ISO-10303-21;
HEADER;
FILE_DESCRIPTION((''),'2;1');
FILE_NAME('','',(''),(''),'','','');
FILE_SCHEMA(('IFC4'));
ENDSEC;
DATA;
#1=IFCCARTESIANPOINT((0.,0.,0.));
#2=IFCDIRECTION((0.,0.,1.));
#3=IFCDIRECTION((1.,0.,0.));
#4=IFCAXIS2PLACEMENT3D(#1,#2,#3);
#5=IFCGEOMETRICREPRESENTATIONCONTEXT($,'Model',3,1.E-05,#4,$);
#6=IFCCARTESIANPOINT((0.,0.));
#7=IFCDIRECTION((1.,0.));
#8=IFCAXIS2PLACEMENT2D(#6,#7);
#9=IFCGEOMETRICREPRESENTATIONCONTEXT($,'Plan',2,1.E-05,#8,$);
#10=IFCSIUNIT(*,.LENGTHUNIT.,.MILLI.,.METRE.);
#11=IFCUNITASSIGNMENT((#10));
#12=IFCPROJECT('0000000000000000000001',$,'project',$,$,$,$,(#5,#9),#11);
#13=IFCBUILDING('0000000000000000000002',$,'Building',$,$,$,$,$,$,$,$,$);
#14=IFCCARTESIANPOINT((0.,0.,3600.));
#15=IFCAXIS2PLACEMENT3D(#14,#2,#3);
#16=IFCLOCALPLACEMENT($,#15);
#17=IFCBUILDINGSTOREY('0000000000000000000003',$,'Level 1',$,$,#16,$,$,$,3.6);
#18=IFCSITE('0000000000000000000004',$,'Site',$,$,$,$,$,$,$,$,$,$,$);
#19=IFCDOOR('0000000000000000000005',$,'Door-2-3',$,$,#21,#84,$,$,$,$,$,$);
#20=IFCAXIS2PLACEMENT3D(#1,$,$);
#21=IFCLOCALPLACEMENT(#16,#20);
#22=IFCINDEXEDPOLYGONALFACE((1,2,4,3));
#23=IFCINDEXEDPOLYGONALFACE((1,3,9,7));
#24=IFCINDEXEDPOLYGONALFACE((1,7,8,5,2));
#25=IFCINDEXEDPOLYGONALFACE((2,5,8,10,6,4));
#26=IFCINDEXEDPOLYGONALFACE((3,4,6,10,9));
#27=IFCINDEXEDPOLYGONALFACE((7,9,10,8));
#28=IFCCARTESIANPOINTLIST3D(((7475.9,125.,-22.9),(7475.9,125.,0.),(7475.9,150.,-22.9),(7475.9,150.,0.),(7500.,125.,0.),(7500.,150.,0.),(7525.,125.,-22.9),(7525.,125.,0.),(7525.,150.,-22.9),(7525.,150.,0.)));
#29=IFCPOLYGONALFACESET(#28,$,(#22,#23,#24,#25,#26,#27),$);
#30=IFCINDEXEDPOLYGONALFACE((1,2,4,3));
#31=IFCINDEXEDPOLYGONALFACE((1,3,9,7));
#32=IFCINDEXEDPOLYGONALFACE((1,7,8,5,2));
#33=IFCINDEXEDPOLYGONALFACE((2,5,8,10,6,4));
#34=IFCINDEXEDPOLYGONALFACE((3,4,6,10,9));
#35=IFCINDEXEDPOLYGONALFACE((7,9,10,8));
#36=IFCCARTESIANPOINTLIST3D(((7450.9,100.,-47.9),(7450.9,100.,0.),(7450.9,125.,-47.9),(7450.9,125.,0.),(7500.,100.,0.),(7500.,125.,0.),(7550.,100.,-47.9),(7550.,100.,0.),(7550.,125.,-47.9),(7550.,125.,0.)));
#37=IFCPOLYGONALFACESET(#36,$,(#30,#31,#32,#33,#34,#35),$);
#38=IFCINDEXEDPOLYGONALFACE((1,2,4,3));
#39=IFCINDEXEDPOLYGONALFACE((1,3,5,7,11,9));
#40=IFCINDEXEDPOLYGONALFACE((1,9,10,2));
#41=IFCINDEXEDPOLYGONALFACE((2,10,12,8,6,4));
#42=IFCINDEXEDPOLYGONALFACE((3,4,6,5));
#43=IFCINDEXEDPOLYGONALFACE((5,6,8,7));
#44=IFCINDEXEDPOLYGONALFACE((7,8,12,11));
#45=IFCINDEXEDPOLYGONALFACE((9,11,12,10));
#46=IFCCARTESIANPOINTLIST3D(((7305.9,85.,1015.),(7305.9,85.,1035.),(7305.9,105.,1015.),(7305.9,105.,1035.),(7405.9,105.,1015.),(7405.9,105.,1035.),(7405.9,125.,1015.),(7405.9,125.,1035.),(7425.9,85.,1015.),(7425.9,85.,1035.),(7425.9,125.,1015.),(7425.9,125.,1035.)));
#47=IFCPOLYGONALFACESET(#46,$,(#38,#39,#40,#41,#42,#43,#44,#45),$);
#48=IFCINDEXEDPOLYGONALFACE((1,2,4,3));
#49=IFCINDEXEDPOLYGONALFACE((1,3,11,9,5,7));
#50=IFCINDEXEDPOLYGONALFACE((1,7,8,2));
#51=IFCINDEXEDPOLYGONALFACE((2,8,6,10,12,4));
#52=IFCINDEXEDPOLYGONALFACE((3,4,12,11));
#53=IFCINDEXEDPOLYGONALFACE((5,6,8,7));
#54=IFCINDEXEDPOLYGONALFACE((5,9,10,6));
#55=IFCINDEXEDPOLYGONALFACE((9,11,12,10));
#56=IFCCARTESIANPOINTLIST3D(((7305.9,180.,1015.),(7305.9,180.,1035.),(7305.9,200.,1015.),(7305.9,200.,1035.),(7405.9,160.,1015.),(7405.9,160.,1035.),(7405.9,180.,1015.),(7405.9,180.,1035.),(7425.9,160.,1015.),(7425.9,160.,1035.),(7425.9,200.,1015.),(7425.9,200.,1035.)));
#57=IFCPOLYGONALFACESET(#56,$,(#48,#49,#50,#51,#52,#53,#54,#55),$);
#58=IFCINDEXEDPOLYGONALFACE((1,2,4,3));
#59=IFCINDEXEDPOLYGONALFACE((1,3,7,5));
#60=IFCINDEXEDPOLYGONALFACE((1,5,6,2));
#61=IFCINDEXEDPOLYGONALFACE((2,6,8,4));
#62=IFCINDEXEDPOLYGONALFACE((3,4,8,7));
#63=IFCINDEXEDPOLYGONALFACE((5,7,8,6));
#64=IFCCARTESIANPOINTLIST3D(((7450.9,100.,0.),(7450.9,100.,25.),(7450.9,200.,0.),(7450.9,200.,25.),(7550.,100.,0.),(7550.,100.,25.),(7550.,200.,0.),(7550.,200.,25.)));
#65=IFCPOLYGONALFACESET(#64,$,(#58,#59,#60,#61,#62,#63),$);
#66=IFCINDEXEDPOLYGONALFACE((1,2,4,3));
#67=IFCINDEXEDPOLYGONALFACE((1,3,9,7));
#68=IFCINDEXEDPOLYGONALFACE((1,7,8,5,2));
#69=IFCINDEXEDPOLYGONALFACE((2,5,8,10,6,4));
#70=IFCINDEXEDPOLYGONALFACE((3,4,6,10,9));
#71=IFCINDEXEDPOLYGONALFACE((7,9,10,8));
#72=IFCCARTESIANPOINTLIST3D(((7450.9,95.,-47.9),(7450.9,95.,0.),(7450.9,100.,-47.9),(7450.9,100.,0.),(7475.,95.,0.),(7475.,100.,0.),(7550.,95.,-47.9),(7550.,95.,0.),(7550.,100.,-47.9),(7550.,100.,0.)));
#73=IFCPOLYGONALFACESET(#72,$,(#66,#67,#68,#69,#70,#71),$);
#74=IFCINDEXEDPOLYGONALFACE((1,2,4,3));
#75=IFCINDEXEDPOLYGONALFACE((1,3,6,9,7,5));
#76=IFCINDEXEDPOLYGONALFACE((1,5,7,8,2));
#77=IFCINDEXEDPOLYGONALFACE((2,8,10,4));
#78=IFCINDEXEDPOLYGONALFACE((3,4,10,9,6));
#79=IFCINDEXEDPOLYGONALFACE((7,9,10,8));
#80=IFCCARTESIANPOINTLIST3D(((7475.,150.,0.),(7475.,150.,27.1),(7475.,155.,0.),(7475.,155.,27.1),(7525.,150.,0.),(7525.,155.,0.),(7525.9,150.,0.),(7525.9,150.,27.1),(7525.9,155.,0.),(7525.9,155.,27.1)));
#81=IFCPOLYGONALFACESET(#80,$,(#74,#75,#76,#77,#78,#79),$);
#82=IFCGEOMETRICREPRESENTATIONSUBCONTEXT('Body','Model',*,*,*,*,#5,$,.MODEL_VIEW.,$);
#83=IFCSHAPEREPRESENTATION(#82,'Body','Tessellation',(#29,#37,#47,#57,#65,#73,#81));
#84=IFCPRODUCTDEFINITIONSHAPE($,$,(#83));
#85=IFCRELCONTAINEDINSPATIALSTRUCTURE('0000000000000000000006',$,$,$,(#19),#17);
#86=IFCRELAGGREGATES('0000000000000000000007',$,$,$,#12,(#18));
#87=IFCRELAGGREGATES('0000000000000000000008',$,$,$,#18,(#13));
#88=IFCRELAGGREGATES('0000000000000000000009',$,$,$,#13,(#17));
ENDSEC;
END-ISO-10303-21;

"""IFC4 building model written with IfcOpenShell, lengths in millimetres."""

from ifc_helpers import new_model, si_unit, frame, origin_with_axes, origin_2d_with_axis, place, context, subcontext, project, spatial, line, indexed_curve, outline, extrude, element, save


model = new_model("IFC4")

# Units and contexts
model_context = context("Model", 3, precision=1e-05, world=origin_with_axes())
plan_context = context("Plan", 2, precision=1e-05, world=origin_2d_with_axis())
body_context = subcontext(model_context, "Body", "Model", "MODEL_VIEW")
ifc_project = project(units=[si_unit("LENGTHUNIT", "METRE", prefix="MILLI")], contexts=[model_context, plan_context])

# Site, building, storey
site = spatial("IfcSite", under=ifc_project, Name="Site")
building = spatial("IfcBuilding", under=site, Name="Building")
storey_placement = place(None, frame((0.0, 0.0, 3600.0), z_axis=(0.0, 0.0, 1.0), x_axis=(1.0, 0.0, 0.0)))
storey = spatial("IfcBuildingStorey", under=building, at=storey_placement, Name="Level 1", Elevation=3.6)

# Door
door_1_placement = place(storey_placement, frame((7500.0, 100.0, 0.0), z_axis=(0.0, 0.0, 1.0), x_axis=(1.0, 0.0, 0.0)))
element("IfcDoor", 1, at=door_1_placement, inside=storey, Name="Door-2-3", context=body_context, shape_type="SweptSolid", body=[
    extrude(outline(indexed_curve([(0.0, 0.0), (0.0, 2.1), (0.9, 2.1), (0.9, 0.0), (-24.1, 0.0), (-24.1, -22.9), (25.0, -22.9), (25.0, 0.0)], segments=[line(1, 2, 3, 4, 5, 6, 7, 8, 1)])), frame((0.0, 25.0, 0.0), z_axis=(0.0, -1.0, 0.0), x_axis=(1.0, 0.0, 0.0)), (0.0, 0.0, -1.0), 25.0),
    extrude(outline(indexed_curve([(0.0, 0.0), (0.0, 2.1), (0.9, 2.1), (0.9, 0.0), (-49.1, 0.0), (-49.1, -47.9), (50.0, -47.9), (50.0, 0.0)], segments=[line(1, 2, 3, 4, 5, 6, 7, 8, 1)])), frame((0.0, 0.0, 0.0), z_axis=(0.0, -1.0, 0.0), x_axis=(1.0, 0.0, 0.0)), (0.0, 0.0, -1.0), 25.0),
    extrude(outline(indexed_curve([(0.0, 0.0), (-49.1, 0.0), (-49.1, 35.0), (0.0, 35.0)], segments=[line(1, 2, 3, 4, 1)])), frame((25.0, 25.0, 25.0), z_axis=(0.0, 0.0, 1.0), x_axis=(1.0, 0.0, 0.0)), (0.0, 0.0, 1.0), -47.9),
    extrude(outline(indexed_curve([(0.0, 0.0), (0.0, -40.0), (-120.0, -40.0), (-120.0, -20.0), (-20.0, -20.0), (-20.0, 0.0)], segments=[line(1, 2, 3, 4, 5, 6, 1)])), frame((-74.1, 25.0, 1015.0), z_axis=(0.0, 0.0, 1.0), x_axis=(1.0, 0.0, 0.0)), (0.0, 0.0, 1.0), 20.0),
    extrude(outline(indexed_curve([(0.0, 0.0), (0.0, 40.0), (-120.0, 40.0), (-120.0, 20.0), (-20.0, 20.0), (-20.0, 0.0)], segments=[line(1, 2, 3, 4, 5, 6, 1)])), frame((-74.1, 60.0, 1015.0), z_axis=(0.0, 0.0, 1.0), x_axis=(1.0, 0.0, 0.0)), (0.0, 0.0, 1.0), 20.0),
    extrude(outline(indexed_curve([(0.0, 0.0), (-99.1, 0.0), (-99.1, 100.0), (0.0, 100.0)], segments=[line(1, 2, 3, 4, 1)])), frame((50.0, 0.0, 0.0), z_axis=(0.0, 0.0, 1.0), x_axis=(1.0, 0.0, 0.0)), (0.0, 0.0, 1.0), 25.0),
    extrude(outline(indexed_curve([(0.0, 0.0), (0.0, 27.1), (50.9, 27.1), (50.9, 0.0), (-24.1, 0.0), (-24.1, -47.9), (75.0, -47.9), (75.0, 0.0)], segments=[line(1, 2, 3, 4, 5, 6, 7, 8, 1)])), frame((-25.0, -5.0, 0.0), z_axis=(0.0, -1.0, 0.0), x_axis=(1.0, 0.0, 0.0)), (0.0, 0.0, -1.0), 5.0),
    extrude(outline(indexed_curve([(0.0, 0.0), (0.0, 27.1), (50.9, 27.1), (50.9, 0.0), (0.9, 0.0), (0.9, -22.9), (50.0, -22.9), (50.0, 0.0)], segments=[line(1, 2, 3, 4, 5, 6, 7, 8, 1)])), frame((-25.0, 50.0, 0.0), z_axis=(0.0, -1.0, 0.0), x_axis=(1.0, 0.0, 0.0)), (0.0, 0.0, -1.0), 5.0),
])

save(model, "model.ifc")
